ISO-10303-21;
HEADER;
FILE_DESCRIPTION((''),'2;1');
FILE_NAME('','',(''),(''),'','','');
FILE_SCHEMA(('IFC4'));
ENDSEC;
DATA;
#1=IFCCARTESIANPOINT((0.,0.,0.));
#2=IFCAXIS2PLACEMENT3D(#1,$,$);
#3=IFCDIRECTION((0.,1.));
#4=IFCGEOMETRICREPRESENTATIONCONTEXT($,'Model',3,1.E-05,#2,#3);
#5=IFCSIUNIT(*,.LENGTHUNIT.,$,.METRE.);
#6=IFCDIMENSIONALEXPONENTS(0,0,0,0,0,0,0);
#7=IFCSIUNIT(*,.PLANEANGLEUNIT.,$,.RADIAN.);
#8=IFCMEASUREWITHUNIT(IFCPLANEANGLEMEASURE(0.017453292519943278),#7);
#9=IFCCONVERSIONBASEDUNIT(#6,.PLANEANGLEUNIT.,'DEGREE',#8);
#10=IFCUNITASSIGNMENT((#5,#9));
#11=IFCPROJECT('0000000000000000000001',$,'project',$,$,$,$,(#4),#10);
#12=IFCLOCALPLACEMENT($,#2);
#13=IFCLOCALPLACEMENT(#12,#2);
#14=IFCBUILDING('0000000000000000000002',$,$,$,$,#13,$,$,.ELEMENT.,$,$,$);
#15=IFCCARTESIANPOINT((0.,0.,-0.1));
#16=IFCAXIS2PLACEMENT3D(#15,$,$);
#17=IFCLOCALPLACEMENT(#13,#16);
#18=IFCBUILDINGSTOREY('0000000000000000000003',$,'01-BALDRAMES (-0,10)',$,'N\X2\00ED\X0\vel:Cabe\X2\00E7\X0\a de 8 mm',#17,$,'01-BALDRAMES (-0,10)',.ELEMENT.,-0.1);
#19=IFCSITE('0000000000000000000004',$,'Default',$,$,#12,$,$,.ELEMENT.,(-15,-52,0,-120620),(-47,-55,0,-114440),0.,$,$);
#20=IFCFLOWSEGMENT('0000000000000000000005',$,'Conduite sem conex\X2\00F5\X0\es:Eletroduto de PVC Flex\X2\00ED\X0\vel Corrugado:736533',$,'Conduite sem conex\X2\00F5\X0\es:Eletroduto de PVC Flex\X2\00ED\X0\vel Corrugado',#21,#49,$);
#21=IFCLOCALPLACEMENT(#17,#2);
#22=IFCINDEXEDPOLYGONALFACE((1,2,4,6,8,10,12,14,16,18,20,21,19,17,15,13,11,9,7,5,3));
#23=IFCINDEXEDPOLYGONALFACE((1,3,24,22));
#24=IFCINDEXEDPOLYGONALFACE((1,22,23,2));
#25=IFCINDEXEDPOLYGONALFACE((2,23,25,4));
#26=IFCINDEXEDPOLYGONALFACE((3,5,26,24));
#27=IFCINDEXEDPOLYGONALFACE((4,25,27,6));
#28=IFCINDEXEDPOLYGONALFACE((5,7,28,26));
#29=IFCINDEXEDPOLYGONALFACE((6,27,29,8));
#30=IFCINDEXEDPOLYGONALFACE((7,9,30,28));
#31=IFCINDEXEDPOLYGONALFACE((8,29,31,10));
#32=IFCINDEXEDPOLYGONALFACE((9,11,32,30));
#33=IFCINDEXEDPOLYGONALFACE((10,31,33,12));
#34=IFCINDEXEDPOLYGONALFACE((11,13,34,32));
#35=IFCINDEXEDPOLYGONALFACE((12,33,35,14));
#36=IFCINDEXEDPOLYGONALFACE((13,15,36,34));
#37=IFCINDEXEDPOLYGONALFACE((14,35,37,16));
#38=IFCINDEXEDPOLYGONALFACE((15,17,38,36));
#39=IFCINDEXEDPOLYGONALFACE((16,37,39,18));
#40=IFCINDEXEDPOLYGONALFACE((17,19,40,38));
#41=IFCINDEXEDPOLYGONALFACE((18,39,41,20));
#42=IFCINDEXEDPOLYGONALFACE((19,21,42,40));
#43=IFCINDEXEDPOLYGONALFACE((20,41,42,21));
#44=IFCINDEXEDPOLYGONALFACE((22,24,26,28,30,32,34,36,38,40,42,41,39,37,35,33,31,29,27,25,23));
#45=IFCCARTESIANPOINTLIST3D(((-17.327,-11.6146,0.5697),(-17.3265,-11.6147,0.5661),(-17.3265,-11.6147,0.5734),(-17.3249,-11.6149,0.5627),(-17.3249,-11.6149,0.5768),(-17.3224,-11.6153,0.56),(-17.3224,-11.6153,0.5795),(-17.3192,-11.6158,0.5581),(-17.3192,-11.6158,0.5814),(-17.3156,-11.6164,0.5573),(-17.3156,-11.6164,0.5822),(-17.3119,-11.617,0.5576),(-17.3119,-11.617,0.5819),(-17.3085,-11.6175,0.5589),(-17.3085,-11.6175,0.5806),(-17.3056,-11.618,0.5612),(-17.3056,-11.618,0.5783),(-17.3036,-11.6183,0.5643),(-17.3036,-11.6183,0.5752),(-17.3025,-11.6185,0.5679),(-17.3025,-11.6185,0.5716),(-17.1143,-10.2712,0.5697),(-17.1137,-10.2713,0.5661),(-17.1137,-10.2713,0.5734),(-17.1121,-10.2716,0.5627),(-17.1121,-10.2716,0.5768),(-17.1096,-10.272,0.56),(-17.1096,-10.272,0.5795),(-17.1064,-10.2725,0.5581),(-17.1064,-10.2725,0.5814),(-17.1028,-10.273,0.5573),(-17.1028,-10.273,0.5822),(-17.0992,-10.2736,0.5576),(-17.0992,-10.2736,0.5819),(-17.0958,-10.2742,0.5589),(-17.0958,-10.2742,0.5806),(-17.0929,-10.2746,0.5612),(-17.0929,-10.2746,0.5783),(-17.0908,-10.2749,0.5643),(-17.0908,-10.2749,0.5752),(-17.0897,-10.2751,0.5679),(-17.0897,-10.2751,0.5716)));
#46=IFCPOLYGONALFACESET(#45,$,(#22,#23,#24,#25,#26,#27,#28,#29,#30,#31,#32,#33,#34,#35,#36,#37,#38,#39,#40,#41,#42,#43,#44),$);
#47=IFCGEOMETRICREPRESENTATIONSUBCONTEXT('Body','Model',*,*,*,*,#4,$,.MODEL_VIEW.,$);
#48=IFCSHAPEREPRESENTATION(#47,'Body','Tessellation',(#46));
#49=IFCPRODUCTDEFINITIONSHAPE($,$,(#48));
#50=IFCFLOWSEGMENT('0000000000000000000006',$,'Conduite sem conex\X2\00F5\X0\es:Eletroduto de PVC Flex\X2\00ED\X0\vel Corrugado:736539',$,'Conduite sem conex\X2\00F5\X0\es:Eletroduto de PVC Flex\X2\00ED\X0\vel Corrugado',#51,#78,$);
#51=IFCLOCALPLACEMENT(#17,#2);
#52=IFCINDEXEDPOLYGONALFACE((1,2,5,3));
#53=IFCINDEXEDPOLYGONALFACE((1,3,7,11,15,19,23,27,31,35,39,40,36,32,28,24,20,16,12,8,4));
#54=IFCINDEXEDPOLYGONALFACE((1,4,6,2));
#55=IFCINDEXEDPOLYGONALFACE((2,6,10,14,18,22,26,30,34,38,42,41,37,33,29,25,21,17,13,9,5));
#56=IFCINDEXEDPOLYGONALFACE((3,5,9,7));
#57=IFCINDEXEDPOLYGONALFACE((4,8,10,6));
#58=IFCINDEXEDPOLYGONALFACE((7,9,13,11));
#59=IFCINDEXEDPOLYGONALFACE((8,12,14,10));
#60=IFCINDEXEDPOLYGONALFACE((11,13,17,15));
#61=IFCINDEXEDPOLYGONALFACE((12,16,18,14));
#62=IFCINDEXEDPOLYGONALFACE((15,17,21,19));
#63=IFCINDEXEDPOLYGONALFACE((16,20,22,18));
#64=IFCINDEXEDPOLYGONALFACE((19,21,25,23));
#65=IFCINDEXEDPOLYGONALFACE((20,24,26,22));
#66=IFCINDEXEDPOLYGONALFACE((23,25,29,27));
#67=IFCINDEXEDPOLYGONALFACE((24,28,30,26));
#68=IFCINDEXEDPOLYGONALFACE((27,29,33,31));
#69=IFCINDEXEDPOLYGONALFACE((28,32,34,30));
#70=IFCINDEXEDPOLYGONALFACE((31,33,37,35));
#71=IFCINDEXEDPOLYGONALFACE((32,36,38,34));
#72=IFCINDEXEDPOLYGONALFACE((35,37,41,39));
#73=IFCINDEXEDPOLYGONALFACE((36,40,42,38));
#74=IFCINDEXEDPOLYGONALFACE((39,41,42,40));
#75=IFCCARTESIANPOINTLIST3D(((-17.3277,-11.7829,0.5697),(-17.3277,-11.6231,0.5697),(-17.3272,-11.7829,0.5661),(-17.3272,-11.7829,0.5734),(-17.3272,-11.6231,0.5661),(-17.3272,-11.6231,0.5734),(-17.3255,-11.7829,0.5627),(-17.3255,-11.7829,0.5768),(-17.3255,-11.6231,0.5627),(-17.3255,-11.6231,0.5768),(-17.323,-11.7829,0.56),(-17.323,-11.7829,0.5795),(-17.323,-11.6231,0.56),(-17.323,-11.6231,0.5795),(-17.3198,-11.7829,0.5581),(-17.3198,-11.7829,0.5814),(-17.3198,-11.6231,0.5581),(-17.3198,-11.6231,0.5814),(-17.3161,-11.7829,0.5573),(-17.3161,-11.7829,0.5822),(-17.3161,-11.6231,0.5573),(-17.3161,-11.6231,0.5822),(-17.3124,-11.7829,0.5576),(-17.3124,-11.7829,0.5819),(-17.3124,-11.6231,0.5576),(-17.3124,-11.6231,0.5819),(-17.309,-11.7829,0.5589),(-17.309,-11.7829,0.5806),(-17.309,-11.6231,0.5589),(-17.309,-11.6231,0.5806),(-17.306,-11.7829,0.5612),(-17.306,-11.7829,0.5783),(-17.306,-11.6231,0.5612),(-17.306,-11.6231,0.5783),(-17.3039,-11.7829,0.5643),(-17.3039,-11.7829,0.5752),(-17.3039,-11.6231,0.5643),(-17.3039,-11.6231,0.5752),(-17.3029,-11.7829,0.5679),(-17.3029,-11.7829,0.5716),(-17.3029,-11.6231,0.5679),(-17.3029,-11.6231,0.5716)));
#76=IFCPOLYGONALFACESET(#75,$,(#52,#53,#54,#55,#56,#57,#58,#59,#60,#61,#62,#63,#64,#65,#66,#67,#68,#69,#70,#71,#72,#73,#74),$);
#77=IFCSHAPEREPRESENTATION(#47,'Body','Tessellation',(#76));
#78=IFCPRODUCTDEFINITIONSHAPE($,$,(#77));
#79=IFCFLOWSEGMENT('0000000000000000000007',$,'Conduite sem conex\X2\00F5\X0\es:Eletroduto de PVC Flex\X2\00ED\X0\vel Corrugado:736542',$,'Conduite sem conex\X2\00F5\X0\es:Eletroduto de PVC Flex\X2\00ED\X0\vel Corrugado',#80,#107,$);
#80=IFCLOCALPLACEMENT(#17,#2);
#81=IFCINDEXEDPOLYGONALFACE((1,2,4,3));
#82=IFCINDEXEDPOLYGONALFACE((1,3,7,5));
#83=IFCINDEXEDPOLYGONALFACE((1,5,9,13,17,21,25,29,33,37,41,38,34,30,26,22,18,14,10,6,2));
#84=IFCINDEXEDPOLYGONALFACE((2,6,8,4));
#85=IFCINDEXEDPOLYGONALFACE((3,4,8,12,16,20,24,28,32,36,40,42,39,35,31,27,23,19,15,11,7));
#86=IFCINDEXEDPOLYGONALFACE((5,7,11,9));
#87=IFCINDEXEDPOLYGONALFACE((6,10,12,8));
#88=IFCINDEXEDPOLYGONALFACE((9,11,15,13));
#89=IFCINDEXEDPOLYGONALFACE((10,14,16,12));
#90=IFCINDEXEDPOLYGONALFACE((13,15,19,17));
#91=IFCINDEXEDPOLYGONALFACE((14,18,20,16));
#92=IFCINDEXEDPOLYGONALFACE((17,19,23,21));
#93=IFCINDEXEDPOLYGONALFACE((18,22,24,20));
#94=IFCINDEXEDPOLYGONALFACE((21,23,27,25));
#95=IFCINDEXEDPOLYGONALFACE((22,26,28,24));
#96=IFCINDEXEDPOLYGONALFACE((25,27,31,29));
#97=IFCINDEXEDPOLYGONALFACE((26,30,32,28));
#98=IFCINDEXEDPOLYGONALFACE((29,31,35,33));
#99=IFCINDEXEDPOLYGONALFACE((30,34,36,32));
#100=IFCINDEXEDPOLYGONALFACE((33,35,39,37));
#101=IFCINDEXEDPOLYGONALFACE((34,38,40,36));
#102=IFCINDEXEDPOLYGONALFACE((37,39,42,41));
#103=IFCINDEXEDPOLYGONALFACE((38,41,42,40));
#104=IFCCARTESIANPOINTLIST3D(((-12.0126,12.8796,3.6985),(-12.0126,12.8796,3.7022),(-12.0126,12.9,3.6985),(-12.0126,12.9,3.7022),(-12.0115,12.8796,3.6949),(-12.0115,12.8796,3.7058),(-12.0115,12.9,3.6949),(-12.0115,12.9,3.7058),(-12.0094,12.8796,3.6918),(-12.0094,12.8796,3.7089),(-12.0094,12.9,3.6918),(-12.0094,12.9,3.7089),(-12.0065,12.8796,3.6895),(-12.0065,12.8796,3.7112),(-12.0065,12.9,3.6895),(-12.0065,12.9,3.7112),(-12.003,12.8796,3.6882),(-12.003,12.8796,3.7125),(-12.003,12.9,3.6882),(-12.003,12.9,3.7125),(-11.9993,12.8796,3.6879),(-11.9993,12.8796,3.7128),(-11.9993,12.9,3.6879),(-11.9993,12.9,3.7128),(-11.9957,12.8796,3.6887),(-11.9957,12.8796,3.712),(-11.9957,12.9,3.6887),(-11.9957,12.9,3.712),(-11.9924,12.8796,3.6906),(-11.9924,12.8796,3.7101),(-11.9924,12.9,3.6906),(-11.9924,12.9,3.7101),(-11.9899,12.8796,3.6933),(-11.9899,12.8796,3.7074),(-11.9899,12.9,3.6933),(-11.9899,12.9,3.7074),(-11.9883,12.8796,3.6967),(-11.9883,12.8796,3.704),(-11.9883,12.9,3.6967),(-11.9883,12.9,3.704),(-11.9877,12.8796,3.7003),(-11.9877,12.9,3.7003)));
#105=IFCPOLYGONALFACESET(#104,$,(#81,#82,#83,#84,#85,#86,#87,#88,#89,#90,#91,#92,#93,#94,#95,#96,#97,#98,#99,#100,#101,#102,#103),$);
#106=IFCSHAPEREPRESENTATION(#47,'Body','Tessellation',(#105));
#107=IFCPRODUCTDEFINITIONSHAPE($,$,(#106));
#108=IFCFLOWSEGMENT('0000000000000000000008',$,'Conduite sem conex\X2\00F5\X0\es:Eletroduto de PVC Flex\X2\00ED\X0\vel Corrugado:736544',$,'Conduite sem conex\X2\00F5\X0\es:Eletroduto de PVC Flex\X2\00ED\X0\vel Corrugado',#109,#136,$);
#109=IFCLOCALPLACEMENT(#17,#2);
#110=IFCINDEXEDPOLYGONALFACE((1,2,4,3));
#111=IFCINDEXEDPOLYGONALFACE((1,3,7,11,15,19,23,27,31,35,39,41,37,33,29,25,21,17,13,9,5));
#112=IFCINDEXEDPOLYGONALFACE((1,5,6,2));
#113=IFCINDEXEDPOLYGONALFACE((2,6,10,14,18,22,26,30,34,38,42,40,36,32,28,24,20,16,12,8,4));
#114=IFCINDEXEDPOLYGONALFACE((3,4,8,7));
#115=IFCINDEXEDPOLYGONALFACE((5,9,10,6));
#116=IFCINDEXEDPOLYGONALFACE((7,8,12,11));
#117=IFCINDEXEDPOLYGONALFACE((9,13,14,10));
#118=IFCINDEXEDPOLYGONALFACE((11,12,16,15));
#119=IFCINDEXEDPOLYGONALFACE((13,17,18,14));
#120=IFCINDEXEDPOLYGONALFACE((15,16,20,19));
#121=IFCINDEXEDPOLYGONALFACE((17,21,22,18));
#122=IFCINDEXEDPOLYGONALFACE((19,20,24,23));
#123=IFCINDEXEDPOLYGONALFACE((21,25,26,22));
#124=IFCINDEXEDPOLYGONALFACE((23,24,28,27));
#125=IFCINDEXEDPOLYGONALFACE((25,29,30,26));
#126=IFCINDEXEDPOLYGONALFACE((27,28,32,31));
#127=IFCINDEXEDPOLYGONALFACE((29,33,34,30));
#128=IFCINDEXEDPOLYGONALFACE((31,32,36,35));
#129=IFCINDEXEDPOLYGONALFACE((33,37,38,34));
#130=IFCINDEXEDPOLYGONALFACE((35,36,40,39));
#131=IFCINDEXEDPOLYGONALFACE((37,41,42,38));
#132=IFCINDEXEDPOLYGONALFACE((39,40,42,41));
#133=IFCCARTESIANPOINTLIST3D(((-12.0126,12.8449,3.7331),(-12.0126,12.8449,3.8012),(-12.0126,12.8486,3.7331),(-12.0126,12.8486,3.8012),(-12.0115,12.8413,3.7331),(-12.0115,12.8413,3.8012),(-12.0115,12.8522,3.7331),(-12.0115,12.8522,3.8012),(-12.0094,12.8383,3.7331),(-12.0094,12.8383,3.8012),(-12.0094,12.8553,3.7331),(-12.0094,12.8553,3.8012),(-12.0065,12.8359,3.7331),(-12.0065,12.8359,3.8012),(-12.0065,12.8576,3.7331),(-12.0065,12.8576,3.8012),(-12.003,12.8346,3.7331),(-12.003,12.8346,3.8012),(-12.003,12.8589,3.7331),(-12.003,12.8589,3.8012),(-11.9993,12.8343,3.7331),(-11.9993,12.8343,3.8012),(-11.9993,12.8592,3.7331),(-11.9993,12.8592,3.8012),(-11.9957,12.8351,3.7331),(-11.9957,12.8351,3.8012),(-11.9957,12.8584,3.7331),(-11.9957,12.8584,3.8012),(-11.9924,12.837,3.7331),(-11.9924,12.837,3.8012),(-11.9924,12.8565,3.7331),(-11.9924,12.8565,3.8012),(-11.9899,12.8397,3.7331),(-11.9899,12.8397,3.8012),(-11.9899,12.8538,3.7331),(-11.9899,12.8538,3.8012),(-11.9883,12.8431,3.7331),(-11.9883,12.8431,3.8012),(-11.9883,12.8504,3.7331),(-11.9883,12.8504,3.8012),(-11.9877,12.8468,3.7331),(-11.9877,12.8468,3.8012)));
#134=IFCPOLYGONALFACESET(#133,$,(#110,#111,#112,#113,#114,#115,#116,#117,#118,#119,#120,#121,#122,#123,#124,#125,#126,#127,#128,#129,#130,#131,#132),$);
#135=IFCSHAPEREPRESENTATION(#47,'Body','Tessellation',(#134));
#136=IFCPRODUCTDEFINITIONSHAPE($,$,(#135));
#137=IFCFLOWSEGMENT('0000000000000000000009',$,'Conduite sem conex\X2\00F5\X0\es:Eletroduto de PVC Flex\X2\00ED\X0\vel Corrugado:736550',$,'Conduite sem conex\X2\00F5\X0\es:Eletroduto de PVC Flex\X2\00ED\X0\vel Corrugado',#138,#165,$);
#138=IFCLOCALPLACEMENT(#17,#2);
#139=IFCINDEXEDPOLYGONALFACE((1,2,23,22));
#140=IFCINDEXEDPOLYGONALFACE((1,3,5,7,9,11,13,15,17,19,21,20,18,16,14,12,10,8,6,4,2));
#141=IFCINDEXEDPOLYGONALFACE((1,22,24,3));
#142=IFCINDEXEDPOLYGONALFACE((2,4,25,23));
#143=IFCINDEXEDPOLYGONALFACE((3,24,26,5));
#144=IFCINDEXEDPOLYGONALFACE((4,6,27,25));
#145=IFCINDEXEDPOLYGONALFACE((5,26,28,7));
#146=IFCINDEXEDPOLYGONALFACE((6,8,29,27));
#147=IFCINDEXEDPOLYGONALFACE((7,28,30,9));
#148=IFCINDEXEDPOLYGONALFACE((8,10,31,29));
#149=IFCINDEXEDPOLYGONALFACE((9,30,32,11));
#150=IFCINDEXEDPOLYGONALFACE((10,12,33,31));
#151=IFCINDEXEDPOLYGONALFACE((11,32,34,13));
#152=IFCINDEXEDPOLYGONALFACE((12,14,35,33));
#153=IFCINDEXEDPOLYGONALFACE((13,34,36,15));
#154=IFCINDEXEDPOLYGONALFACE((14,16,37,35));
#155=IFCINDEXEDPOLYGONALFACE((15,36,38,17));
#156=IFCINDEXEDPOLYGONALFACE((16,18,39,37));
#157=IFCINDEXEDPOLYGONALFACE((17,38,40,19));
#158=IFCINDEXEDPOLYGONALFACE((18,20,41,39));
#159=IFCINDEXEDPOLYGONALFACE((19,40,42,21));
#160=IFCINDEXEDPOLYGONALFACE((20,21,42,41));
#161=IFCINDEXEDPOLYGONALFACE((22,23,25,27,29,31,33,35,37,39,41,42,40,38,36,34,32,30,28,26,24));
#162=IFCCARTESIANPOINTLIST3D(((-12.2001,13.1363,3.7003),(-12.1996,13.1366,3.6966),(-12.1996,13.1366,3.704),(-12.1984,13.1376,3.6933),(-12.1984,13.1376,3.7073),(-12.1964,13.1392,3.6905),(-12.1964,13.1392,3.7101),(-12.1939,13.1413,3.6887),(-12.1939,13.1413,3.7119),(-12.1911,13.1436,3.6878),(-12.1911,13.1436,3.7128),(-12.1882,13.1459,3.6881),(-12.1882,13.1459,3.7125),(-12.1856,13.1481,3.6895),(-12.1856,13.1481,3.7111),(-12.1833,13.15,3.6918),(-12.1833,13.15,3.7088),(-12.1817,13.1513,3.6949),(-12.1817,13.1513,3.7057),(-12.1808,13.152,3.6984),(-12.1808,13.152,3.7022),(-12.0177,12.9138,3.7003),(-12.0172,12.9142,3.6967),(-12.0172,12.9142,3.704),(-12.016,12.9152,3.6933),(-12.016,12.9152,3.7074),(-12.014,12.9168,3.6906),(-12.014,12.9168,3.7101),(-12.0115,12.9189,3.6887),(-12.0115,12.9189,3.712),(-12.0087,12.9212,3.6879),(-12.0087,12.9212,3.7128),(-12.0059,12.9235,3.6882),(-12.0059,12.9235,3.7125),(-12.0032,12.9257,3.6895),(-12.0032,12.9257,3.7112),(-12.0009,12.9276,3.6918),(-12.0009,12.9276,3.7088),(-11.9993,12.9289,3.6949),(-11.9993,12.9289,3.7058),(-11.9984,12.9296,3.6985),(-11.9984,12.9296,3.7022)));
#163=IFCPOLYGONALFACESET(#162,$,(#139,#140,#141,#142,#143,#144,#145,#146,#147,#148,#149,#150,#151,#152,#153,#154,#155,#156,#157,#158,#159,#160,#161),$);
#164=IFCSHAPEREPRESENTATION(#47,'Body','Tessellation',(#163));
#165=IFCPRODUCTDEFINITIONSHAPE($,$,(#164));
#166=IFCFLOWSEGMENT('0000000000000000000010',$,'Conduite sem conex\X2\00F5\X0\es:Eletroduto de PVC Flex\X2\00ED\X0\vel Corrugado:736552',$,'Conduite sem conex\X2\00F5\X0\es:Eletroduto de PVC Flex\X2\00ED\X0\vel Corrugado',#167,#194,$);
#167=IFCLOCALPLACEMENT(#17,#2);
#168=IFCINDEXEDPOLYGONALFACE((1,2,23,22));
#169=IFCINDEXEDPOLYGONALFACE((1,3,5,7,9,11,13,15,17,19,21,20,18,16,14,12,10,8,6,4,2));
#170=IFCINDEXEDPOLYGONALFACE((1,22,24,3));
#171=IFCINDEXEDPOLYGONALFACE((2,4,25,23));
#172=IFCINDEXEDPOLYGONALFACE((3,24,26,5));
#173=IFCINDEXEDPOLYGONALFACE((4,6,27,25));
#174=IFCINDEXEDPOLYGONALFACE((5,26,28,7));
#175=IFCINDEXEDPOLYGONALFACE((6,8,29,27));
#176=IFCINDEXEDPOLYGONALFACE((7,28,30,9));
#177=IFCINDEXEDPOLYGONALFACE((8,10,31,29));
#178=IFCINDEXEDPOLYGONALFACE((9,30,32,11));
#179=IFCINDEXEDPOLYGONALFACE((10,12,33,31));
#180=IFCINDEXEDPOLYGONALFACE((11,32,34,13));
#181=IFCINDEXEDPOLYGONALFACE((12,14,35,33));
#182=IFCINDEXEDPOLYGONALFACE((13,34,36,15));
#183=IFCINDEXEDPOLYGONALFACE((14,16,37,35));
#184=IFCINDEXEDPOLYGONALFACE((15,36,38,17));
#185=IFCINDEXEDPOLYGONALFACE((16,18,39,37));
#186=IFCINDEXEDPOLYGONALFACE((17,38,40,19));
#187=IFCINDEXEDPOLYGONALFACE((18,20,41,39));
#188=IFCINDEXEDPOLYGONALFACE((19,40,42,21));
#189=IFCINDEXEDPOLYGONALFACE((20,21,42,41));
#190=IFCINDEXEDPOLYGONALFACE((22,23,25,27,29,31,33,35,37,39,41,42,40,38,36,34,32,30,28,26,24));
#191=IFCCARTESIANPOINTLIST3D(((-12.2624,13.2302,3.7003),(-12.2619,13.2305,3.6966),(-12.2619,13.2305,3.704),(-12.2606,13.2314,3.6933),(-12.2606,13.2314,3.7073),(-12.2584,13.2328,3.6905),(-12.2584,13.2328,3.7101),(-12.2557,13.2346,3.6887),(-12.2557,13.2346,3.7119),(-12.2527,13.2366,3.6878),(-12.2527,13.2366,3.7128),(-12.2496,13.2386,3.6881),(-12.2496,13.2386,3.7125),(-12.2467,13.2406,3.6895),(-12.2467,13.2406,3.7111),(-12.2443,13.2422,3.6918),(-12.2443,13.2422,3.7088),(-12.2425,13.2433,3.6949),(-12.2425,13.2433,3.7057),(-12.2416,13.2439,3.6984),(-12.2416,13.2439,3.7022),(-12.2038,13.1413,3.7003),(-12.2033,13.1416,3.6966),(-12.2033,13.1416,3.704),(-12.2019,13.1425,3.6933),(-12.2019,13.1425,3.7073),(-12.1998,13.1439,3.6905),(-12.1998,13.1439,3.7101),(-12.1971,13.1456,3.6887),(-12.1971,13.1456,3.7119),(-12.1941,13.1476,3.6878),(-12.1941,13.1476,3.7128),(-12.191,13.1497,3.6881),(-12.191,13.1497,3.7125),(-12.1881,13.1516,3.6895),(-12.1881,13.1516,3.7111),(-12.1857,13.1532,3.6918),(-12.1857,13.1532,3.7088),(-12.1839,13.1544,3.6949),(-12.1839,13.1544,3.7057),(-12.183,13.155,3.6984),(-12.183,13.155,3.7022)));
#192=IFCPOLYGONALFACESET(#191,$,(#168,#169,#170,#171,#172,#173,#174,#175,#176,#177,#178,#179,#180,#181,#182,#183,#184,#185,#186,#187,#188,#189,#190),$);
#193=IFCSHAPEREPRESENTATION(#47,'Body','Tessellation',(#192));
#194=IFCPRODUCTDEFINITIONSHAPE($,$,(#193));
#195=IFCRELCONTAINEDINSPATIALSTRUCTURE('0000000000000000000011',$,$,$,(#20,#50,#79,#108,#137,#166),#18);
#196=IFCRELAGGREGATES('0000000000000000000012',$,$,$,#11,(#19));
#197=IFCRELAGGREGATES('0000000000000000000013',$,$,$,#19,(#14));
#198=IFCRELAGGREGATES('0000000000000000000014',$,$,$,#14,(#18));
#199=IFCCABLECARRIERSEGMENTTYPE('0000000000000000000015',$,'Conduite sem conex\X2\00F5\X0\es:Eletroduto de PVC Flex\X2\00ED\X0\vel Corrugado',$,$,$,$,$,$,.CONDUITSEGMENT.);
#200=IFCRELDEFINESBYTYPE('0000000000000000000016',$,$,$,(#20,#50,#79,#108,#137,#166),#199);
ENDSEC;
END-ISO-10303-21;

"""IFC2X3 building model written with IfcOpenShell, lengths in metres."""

from ifc_helpers import new_model, entity, si_unit, converted_unit, direction, frame, frame_2d, origin, origin_2d_with_axis, place, context, subcontext, project, spatial, circle, extrude, type_object, element, save


model = new_model("IFC2X3")

# Units and contexts
model_context = context("Model", 3, precision=1e-05, world=origin(), true_north=direction((0.0, 1.0)))
body_context = subcontext(model_context, "Body", "Model", "MODEL_VIEW")
ifc_project = project(units=[si_unit("LENGTHUNIT", "METRE"), converted_unit("PLANEANGLEUNIT", "DEGREE", entity("IfcPlaneAngleMeasure", 0.017453292519943278), si_unit("PLANEANGLEUNIT", "RADIAN"), dimensions=[0, 0, 0, 0, 0, 0, 0])], contexts=[model_context])

# Site, building, storey
site_placement = place(None, origin())
site = spatial("IfcSite", under=ifc_project, at=site_placement, Name="Default", CompositionType="ELEMENT", RefLatitude=(-15, -52, 0, -120620), RefLongitude=(-47, -55, 0, -114440), RefElevation=0.0)
building_placement = place(site_placement, origin())
building = spatial("IfcBuilding", under=site, at=building_placement, CompositionType="ELEMENT")
storey_placement = place(building_placement, frame((0.0, 0.0, -0.1)))
storey = spatial("IfcBuildingStorey", under=building, at=storey_placement, Name="01-BALDRAMES (-0,10)", ObjectType="Nível:Cabeça de 8 mm", LongName="01-BALDRAMES (-0,10)", CompositionType="ELEMENT", Elevation=-0.1)

# Flow segments
cable_carrier_segment_type = type_object("IfcCableCarrierSegmentType", Name="Conduite sem conexões:Eletroduto de PVC Flexível Corrugado", PredefinedType="CONDUITSEGMENT")
flow_segment_1_placement = place(storey_placement, origin())
element("IfcFlowSegment", 1, at=flow_segment_1_placement, inside=storey, type_object=cable_carrier_segment_type, Name="Conduite sem conexões:Eletroduto de PVC Flexível Corrugado:736533", ObjectType="Conduite sem conexões:Eletroduto de PVC Flexível Corrugado", context=body_context, shape_type="SweptSolid", body=[
    extrude(circle(Radius=0.0125, at=origin_2d_with_axis()), frame((-17.3147, -11.6165, 0.5697), z_axis=(0.156434, 0.987688, 0.0), x_axis=(-0.987688, 0.156434, 0.0)), (0.0, 0.0, 1.0), 1.3601),
])
flow_segment_2_placement = place(storey_placement, origin())
element("IfcFlowSegment", 2, at=flow_segment_2_placement, inside=storey, type_object=cable_carrier_segment_type, Name="Conduite sem conexões:Eletroduto de PVC Flexível Corrugado:736539", ObjectType="Conduite sem conexões:Eletroduto de PVC Flexível Corrugado", context=body_context, shape_type="SweptSolid", body=[
    extrude(circle(Radius=0.0125, at=frame_2d((0.0, 0.0), x_axis=(1.0, 0.0))), frame((-17.3152, -11.7829, 0.5697), z_axis=(0.0, 1.0, 0.0), x_axis=(-1.0, 0.0, 0.0)), (0.0, 0.0, 1.0), 0.1597),
])
flow_segment_3_placement = place(storey_placement, origin())
element("IfcFlowSegment", 3, at=flow_segment_3_placement, inside=storey, type_object=cable_carrier_segment_type, Name="Conduite sem conexões:Eletroduto de PVC Flexível Corrugado:736542", ObjectType="Conduite sem conexões:Eletroduto de PVC Flexível Corrugado", context=body_context, shape_type="SweptSolid", body=[
    extrude(circle(Radius=0.0125, at=origin_2d_with_axis()), frame((-12.0002, 12.8796, 3.7003), z_axis=(0.0, 1.0, 0.0), x_axis=(1.0, 0.0, 0.0)), (0.0, 0.0, 1.0), 0.0205),
])
flow_segment_4_placement = place(storey_placement, origin())
element("IfcFlowSegment", 4, at=flow_segment_4_placement, inside=storey, type_object=cable_carrier_segment_type, Name="Conduite sem conexões:Eletroduto de PVC Flexível Corrugado:736544", ObjectType="Conduite sem conexões:Eletroduto de PVC Flexível Corrugado", context=body_context, shape_type="SweptSolid", body=[
    extrude(circle(Radius=0.0125, at=frame_2d((0.0, 0.0), x_axis=(1.0, 0.0))), frame((-12.0002, 12.8468, 3.7331)), (0.0, 0.0, 1.0), 0.0681),
])
flow_segment_5_placement = place(storey_placement, origin())
element("IfcFlowSegment", 5, at=flow_segment_5_placement, inside=storey, type_object=cable_carrier_segment_type, Name="Conduite sem conexões:Eletroduto de PVC Flexível Corrugado:736550", ObjectType="Conduite sem conexões:Eletroduto de PVC Flexível Corrugado", context=body_context, shape_type="SweptSolid", body=[
    extrude(circle(Radius=0.0125, at=origin_2d_with_axis()), frame((-12.008, 12.9218, 3.7003), z_axis=(-0.634082, 0.773266, -0.000166), x_axis=(-0.773266, -0.634082, 0.0)), (0.0, 0.0, 1.0), 0.2876),
])
flow_segment_6_placement = place(storey_placement, origin())
element("IfcFlowSegment", 6, at=flow_segment_6_placement, inside=storey, type_object=cable_carrier_segment_type, Name="Conduite sem conexões:Eletroduto de PVC Flexível Corrugado:736552", ObjectType="Conduite sem conexões:Eletroduto de PVC Flexível Corrugado", context=body_context, shape_type="SweptSolid", body=[
    extrude(circle(Radius=0.0125, at=origin_2d_with_axis()), frame((-12.2519, 13.2371, 3.7003), z_axis=(0.550118, -0.835087, 0.0), x_axis=(-0.835087, -0.550118, 0.0)), (0.0, 0.0, 1.0), 0.1065),
])

save(model, "model.ifc")
